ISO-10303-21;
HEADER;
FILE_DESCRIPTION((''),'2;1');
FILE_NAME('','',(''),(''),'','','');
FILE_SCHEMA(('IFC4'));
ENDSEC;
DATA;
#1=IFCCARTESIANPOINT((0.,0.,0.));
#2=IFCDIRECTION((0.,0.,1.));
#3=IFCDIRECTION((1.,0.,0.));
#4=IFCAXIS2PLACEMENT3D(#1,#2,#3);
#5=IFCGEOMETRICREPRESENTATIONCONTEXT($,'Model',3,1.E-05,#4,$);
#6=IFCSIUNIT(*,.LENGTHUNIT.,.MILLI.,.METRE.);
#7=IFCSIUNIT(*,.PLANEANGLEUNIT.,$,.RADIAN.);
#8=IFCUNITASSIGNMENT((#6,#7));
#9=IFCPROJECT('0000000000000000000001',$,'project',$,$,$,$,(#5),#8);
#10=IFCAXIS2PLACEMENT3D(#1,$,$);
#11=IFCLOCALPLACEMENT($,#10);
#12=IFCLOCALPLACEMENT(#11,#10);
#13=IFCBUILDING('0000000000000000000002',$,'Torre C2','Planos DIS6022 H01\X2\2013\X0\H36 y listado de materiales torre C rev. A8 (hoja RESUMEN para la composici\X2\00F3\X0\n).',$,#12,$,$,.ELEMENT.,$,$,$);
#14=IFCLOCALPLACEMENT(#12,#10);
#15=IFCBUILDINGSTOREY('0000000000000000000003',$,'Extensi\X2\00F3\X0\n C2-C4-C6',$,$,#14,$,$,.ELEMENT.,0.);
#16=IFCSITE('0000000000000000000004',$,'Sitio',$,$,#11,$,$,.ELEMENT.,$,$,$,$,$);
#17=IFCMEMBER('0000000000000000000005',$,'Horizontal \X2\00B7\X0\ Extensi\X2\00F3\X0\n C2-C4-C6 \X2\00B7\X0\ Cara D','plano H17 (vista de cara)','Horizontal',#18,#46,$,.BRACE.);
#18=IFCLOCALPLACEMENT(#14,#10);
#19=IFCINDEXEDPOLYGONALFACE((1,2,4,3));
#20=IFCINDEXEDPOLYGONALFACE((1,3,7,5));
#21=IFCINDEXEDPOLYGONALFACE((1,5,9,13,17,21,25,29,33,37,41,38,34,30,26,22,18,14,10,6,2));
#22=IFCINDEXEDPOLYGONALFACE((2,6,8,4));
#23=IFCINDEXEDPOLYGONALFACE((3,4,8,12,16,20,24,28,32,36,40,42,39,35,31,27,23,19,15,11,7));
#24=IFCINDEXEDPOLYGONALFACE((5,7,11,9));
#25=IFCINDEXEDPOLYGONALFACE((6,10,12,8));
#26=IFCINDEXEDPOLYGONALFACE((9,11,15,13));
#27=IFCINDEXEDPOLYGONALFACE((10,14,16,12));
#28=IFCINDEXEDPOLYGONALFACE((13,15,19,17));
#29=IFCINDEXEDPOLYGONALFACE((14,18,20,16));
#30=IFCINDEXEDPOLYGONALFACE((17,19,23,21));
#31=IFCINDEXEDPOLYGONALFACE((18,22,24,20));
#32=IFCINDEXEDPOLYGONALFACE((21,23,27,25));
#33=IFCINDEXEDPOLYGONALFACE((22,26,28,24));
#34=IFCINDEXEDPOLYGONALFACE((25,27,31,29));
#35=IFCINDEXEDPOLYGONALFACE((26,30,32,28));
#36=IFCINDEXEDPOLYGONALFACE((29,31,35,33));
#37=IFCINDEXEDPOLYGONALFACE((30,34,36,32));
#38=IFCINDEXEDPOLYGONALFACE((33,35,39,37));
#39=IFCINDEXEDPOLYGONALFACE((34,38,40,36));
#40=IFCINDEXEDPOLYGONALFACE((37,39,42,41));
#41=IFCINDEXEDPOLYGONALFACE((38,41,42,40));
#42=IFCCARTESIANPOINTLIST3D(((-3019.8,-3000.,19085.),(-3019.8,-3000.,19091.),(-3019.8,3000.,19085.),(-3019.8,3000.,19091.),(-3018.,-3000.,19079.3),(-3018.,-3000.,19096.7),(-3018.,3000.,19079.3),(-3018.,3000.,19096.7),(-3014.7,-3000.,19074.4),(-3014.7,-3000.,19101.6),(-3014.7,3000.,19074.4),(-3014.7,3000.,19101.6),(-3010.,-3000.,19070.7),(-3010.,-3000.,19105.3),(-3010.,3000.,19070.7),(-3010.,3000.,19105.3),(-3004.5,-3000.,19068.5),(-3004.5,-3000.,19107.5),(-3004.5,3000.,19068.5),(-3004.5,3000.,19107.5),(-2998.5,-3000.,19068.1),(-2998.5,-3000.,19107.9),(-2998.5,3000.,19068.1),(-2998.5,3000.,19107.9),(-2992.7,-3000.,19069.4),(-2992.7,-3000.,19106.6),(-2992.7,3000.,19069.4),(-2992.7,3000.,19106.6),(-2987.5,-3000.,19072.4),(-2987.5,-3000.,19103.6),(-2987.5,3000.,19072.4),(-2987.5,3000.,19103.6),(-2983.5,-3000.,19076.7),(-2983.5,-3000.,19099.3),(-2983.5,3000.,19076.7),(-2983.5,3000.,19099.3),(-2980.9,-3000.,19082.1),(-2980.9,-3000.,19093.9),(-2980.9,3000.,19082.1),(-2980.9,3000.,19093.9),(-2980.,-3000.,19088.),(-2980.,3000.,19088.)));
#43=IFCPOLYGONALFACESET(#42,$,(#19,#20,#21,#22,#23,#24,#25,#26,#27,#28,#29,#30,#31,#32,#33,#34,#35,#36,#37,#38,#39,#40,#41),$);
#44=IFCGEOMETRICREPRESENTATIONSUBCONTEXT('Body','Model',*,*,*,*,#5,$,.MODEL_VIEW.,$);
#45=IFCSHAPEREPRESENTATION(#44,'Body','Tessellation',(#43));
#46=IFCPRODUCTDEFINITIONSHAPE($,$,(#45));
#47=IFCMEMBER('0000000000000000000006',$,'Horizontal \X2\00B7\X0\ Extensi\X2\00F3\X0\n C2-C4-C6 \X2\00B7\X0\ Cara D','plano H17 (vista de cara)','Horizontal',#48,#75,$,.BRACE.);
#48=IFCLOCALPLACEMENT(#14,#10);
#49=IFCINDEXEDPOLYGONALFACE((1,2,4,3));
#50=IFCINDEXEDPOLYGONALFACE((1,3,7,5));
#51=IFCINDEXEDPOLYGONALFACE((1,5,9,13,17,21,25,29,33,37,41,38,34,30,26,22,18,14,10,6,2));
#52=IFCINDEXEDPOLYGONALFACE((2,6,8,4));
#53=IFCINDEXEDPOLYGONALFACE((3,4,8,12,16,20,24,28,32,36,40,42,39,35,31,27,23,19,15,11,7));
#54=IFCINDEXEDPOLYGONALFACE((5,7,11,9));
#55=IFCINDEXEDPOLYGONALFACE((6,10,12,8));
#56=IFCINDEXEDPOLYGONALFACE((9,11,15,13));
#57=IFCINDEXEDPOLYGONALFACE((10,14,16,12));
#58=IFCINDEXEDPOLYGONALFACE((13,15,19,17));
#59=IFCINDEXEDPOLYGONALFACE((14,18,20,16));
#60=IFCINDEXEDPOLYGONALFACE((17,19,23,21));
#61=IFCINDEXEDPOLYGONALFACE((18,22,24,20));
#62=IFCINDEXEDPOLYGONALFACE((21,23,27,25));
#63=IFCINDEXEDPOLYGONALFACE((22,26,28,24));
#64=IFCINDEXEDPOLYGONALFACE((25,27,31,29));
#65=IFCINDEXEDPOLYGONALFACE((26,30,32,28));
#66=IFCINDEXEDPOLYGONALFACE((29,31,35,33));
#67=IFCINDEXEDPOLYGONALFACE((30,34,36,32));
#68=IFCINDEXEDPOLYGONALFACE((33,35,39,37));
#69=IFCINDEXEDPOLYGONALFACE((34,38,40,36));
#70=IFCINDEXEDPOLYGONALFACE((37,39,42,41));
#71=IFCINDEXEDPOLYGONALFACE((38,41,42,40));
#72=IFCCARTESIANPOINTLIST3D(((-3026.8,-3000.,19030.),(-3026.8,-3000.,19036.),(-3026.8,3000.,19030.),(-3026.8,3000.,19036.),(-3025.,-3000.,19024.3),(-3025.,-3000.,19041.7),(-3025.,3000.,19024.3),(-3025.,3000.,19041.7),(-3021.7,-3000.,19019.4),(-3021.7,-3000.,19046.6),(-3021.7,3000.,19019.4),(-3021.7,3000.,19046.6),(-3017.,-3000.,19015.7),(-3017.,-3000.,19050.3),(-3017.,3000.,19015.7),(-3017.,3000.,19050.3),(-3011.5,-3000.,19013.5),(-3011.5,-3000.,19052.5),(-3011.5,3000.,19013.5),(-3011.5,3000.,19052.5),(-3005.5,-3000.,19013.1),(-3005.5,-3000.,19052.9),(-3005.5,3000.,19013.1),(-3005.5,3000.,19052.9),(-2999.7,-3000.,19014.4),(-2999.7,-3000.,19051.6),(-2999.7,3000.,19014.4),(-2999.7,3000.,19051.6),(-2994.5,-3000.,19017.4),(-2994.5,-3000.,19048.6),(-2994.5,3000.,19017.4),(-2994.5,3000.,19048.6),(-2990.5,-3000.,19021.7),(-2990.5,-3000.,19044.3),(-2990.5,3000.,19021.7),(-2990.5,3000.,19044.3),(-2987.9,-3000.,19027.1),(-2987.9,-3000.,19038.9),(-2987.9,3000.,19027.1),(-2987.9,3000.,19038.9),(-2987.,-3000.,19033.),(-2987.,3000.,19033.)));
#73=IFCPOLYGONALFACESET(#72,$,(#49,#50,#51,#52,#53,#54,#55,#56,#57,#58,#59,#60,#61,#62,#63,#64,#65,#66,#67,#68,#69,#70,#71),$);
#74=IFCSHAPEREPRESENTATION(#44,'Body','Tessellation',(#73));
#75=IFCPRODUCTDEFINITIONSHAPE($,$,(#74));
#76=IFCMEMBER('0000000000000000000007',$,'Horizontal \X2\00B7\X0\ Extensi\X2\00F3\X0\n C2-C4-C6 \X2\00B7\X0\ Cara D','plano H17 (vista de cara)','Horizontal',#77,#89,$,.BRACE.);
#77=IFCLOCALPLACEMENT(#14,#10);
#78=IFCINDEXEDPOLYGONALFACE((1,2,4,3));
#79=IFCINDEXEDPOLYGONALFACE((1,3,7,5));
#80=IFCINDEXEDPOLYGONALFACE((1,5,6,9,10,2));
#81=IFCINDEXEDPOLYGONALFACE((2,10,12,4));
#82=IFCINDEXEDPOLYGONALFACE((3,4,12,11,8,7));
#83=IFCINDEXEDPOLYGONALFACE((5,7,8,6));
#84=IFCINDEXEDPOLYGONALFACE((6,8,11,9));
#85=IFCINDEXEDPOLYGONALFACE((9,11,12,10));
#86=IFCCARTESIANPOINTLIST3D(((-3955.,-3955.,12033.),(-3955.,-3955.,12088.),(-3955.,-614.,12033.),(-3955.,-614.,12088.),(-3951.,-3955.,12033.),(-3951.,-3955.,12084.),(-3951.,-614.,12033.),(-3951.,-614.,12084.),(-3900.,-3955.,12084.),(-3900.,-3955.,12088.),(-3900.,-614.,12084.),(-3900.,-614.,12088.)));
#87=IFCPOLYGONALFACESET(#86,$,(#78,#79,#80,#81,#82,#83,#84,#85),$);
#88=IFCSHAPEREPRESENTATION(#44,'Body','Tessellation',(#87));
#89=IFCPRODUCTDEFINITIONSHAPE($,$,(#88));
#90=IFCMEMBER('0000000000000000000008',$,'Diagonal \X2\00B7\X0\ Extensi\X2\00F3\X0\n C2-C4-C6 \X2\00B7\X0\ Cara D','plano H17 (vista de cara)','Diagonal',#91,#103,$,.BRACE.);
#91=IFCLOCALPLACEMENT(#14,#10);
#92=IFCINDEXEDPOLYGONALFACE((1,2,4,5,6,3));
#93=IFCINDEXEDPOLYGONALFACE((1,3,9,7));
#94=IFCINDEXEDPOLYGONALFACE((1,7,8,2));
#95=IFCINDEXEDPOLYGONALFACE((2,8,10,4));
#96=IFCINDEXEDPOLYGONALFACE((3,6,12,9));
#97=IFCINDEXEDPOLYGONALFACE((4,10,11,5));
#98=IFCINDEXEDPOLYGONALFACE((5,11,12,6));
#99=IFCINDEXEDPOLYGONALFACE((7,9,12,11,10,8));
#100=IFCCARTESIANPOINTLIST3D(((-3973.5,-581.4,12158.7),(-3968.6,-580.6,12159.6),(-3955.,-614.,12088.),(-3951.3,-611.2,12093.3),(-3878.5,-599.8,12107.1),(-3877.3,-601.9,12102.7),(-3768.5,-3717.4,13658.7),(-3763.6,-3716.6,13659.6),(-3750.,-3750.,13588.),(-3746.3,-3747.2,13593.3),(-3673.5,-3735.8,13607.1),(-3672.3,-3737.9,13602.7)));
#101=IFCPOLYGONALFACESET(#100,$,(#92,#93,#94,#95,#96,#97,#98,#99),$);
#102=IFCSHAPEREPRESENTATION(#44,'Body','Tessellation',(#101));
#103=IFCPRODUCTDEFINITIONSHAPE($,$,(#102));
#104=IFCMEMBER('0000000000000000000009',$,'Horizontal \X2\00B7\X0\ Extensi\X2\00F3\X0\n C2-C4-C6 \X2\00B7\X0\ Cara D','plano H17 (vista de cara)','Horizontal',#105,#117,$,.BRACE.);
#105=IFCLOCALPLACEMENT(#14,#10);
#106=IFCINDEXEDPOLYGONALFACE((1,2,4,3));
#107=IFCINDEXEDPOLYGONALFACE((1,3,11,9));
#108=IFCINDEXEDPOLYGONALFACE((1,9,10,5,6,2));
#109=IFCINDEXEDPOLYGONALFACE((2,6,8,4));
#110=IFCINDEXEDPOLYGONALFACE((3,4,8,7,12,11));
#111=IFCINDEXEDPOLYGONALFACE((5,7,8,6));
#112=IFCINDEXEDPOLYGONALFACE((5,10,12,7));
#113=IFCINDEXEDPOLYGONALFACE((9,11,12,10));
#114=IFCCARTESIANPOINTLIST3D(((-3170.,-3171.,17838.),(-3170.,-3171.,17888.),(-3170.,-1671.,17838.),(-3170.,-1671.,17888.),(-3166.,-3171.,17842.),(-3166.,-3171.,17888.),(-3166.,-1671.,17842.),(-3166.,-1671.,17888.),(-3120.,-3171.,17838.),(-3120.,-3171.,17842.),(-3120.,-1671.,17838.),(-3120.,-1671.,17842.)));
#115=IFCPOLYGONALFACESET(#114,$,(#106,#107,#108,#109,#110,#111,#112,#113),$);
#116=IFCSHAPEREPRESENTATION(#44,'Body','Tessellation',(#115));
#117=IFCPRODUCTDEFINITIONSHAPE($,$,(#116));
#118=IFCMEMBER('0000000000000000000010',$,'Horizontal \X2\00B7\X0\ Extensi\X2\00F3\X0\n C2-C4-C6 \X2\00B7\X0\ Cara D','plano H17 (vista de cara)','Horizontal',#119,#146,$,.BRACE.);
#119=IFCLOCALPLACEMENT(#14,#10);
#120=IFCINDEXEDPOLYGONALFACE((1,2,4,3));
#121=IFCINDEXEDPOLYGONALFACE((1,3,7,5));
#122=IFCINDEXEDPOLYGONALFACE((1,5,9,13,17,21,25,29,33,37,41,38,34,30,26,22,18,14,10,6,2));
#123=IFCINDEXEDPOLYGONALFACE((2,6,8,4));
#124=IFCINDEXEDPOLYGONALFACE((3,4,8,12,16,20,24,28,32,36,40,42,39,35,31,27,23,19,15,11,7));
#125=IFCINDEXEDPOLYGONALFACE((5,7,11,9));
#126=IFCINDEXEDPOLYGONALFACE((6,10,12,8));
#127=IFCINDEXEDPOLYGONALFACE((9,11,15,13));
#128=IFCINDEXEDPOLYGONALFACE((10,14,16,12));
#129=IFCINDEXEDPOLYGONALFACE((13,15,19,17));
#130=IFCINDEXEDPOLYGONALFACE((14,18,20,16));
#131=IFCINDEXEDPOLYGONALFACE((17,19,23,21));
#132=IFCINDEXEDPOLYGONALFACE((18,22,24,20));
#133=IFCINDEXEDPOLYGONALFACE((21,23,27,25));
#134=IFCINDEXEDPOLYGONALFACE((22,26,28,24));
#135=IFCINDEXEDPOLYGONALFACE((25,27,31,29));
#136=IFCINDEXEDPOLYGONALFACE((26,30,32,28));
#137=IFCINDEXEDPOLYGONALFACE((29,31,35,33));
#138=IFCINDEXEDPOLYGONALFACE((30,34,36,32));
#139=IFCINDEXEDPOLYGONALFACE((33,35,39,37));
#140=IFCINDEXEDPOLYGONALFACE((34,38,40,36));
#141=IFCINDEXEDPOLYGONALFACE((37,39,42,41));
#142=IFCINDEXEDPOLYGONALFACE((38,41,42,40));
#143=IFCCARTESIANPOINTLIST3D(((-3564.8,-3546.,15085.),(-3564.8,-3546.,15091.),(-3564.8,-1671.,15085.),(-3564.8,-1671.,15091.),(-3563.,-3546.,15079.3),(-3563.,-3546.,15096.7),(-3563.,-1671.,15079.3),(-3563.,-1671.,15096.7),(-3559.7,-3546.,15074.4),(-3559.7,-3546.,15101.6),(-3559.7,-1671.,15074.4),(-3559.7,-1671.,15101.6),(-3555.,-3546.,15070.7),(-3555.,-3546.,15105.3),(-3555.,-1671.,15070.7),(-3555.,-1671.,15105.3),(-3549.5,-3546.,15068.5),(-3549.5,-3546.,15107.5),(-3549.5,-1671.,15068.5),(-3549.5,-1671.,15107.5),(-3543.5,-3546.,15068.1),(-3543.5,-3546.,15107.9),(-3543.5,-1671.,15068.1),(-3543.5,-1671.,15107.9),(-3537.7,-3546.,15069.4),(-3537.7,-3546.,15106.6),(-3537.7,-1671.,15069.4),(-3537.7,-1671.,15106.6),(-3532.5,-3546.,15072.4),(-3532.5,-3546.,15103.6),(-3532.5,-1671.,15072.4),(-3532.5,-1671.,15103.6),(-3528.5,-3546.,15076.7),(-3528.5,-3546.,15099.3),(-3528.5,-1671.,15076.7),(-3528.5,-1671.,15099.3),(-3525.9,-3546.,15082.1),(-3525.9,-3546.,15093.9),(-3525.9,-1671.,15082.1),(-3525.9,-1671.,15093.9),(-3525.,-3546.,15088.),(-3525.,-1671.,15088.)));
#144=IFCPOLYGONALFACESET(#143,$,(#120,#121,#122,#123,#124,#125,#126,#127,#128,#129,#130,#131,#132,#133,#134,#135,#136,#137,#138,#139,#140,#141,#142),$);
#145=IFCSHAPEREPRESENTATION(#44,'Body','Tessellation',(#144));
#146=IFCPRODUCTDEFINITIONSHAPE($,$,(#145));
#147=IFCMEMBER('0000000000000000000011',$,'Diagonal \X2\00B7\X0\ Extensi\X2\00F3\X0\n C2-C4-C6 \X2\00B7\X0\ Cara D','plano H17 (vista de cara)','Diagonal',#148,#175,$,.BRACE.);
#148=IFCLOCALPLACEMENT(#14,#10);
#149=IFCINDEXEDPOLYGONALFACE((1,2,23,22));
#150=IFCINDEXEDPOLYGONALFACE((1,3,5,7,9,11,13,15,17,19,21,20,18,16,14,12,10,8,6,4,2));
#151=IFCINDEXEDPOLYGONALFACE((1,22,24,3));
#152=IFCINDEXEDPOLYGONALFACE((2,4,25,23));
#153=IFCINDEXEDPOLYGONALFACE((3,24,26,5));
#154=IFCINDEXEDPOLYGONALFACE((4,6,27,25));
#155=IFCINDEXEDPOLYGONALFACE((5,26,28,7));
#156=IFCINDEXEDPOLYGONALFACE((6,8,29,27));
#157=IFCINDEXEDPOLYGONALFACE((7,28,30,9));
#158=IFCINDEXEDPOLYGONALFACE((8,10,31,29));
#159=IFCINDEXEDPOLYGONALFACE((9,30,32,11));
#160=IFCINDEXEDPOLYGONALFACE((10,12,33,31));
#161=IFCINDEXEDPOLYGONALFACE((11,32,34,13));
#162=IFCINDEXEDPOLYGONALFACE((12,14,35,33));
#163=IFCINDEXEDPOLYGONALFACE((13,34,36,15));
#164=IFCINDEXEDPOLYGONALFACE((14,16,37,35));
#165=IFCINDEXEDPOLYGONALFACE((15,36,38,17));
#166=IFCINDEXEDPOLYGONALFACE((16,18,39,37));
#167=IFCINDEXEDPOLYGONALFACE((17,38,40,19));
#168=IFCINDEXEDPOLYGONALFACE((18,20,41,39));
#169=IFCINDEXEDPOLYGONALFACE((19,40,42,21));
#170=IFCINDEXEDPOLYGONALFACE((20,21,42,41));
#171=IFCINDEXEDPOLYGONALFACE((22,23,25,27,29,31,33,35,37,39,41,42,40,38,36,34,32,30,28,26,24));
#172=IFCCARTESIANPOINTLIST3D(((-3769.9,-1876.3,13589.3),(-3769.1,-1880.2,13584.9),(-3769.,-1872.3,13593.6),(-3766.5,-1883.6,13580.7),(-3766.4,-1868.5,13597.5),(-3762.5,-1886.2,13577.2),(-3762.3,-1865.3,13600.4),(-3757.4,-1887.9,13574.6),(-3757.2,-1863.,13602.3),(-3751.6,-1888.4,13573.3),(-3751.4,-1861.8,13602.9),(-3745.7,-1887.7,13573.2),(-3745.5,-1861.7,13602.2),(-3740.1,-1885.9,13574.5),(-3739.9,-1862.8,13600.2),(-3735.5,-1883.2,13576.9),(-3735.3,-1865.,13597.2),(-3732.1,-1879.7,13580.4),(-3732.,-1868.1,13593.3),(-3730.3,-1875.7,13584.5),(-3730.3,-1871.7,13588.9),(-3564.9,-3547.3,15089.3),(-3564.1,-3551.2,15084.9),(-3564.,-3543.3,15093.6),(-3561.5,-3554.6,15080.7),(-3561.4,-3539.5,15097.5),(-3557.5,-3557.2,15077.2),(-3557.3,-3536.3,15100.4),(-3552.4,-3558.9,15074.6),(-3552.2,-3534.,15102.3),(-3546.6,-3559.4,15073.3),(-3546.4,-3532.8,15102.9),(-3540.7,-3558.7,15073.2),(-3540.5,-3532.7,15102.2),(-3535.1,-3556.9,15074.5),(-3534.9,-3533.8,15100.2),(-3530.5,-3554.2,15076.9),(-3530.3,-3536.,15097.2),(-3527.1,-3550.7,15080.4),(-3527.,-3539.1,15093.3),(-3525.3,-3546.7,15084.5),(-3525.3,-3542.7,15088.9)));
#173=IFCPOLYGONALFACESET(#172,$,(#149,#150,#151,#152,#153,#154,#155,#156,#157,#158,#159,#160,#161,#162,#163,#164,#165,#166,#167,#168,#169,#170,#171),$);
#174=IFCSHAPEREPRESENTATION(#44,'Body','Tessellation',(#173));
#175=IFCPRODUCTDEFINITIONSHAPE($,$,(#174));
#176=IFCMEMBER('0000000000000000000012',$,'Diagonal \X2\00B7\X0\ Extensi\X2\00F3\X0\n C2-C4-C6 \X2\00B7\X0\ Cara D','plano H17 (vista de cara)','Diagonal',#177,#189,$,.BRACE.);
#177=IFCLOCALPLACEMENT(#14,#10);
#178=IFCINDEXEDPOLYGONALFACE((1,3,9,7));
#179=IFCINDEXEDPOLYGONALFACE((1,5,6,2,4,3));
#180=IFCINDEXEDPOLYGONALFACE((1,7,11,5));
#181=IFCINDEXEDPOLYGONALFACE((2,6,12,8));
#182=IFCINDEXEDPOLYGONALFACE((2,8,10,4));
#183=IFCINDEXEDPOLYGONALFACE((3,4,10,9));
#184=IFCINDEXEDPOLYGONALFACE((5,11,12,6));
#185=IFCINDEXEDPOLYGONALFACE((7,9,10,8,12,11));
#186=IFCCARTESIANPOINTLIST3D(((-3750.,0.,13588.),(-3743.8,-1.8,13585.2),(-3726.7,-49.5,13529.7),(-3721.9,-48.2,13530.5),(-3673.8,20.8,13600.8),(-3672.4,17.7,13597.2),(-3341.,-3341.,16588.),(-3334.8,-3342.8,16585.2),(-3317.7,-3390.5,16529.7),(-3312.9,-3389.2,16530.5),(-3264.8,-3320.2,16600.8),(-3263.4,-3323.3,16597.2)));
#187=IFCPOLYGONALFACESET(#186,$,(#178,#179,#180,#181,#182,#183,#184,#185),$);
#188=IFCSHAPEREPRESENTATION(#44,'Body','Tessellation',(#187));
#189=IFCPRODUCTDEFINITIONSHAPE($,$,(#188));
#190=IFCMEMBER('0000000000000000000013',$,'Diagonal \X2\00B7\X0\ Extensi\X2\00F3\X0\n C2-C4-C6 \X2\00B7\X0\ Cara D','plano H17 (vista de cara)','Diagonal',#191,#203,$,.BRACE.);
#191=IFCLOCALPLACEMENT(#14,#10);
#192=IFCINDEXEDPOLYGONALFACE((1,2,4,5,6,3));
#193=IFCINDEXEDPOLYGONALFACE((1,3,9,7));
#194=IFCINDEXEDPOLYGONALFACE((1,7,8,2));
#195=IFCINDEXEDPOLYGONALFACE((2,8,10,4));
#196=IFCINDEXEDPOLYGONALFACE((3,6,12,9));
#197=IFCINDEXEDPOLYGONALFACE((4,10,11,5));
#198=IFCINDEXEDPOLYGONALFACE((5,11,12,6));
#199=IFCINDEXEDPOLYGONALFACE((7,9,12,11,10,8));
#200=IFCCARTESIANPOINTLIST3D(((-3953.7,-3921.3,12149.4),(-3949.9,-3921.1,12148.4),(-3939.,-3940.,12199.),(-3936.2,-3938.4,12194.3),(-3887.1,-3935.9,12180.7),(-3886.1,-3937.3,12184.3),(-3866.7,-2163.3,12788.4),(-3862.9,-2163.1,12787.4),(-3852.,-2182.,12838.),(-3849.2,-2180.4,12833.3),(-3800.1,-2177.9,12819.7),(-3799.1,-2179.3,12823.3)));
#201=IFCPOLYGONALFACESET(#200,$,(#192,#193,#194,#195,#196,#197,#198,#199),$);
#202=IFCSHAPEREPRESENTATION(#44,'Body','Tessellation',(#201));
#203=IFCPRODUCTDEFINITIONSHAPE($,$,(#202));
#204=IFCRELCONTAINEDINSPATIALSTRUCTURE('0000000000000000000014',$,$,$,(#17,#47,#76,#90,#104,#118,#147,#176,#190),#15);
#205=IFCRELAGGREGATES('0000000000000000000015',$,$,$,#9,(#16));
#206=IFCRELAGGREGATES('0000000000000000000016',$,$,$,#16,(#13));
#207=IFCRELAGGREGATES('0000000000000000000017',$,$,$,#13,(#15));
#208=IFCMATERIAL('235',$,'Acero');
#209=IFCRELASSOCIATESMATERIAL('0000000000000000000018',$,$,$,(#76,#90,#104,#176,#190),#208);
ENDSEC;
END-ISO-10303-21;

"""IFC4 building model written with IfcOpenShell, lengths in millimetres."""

from ifc_helpers import new_model, si_unit, frame, frame_2d, origin, origin_with_axes, place, context, subcontext, project, spatial, circle, l_section, extrude, material, element, save


model = new_model("IFC4")

# Units and contexts
model_context = context("Model", 3, precision=1e-05, world=origin_with_axes())
body_context = subcontext(model_context, "Body", "Model", "MODEL_VIEW")
ifc_project = project(units=[si_unit("LENGTHUNIT", "METRE", prefix="MILLI"), si_unit("PLANEANGLEUNIT", "RADIAN")], contexts=[model_context])

# Site, building, storey
site_placement = place(None, origin())
site = spatial("IfcSite", under=ifc_project, at=site_placement, Name="Sitio", CompositionType="ELEMENT")
building_placement = place(site_placement, origin())
building = spatial("IfcBuilding", under=site, at=building_placement, Name="Torre C2", Description="Planos DIS6022 H01–H36 y listado de materiales torre C rev. A8 (hoja RESUMEN para la composición).", CompositionType="ELEMENT")
storey_placement = place(building_placement, origin())
storey = spatial("IfcBuildingStorey", under=building, at=storey_placement, Name="Extensión C2-C4-C6", CompositionType="ELEMENT", Elevation=0.0)

# Members
ifc_material_1 = material(Name="235", Category="Acero")
for number, where, z_axis, x_axis, name in (
    (1, (-3000.0, -3000.0, 19088.0), (0.0, 1.0, 0.0), (1.0, 0.0, 0.0), "Horizontal · Extensión C2-C4-C6 · Cara D"),
    (2, (-3007.0, -3000.0, 19033.0), (0.0, 1.0, 0.0), (1.0, 0.0, 0.0), "Horizontal · Extensión C2-C4-C6 · Cara D"),
):
    element("IfcMember", number, at=place(storey_placement, frame(where, z_axis=z_axis, x_axis=x_axis)), inside=storey, Name=name, Description="plano H17 (vista de cara)", ObjectType="Horizontal", PredefinedType="BRACE", context=body_context, shape_type="SweptSolid", body=[
        extrude(circle(Radius=20.0), None, (0.0, 0.0, 1.0), 6000.0),
    ])
member_1_placement = place(storey_placement, frame((-3955.0, -3955.0, 12088.0), z_axis=(0.0, 1.0, 0.0), x_axis=(1.0, 0.0, 0.0)))
element("IfcMember", 3, at=member_1_placement, inside=storey, material=ifc_material_1, Name="Horizontal · Extensión C2-C4-C6 · Cara D", Description="plano H17 (vista de cara)", ObjectType="Horizontal", PredefinedType="BRACE", context=body_context, shape_type="SweptSolid", body=[
    extrude(l_section(Depth=55.0, Width=55.0, Thickness=4.0, at=frame_2d((27.5, 27.5))), None, (0.0, 0.0, 1.0), 3341.0),
])
member_2_placement = place(storey_placement, frame((-3955.0, -614.0, 12088.0), z_axis=(0.058869, -0.90055, 0.430748), x_axis=(0.971215, 0.151437, 0.183871)))
element("IfcMember", 4, at=member_2_placement, inside=storey, material=ifc_material_1, Name="Diagonal · Extensión C2-C4-C6 · Cara D", Description="plano H17 (vista de cara)", ObjectType="Diagonal", PredefinedType="BRACE", context=body_context, shape_type="SweptSolid", body=[
    extrude(l_section(Depth=80.0, Width=80.0, Thickness=5.0, at=frame_2d((40.0, 40.0))), None, (0.0, 0.0, 1.0), 3482.3),
])
member_3_placement = place(storey_placement, frame((-3170.0, -1671.0, 17838.0), z_axis=(0.0, -1.0, 0.0), x_axis=(1.0, 0.0, 0.0)))
element("IfcMember", 5, at=member_3_placement, inside=storey, material=ifc_material_1, Name="Horizontal · Extensión C2-C4-C6 · Cara D", Description="plano H17 (vista de cara)", ObjectType="Horizontal", PredefinedType="BRACE", context=body_context, shape_type="SweptSolid", body=[
    extrude(l_section(Depth=50.0, Width=50.0, Thickness=4.0, at=frame_2d((25.0, 25.0))), None, (0.0, 0.0, 1.0), 1500.0),
])
member_4_placement = place(storey_placement, frame((-3545.0, -1671.0, 15088.0), z_axis=(0.0, -1.0, 0.0), x_axis=(1.0, 0.0, 0.0)))
element("IfcMember", 6, at=member_4_placement, inside=storey, Name="Horizontal · Extensión C2-C4-C6 · Cara D", Description="plano H17 (vista de cara)", ObjectType="Horizontal", PredefinedType="BRACE", context=body_context, shape_type="SweptSolid", body=[
    extrude(circle(Radius=20.0), None, (0.0, 0.0, 1.0), 1875.0),
])
member_5_placement = place(storey_placement, frame((-3545.0, -3546.0, 15088.0), z_axis=(-0.090916, 0.741075, -0.665238), x_axis=(0.899707, 0.347494, 0.264149)))
element("IfcMember", 7, at=member_5_placement, inside=storey, Name="Diagonal · Extensión C2-C4-C6 · Cara D", Description="plano H17 (vista de cara)", ObjectType="Diagonal", PredefinedType="BRACE", context=body_context, shape_type="SweptSolid", body=[
    extrude(circle(Radius=20.0), None, (0.0, 0.0, 1.0), 2254.8),
])
member_6_placement = place(storey_placement, frame((-3341.0, -3341.0, 16588.0), z_axis=(-0.090711, 0.74099, -0.665361), x_axis=(0.952207, 0.260212, 0.159972)))
element("IfcMember", 8, at=member_6_placement, inside=storey, material=ifc_material_1, Name="Diagonal · Extensión C2-C4-C6 · Cara D", Description="plano H17 (vista de cara)", ObjectType="Diagonal", PredefinedType="BRACE", context=body_context, shape_type="SweptSolid", body=[
    extrude(l_section(Depth=80.0, Width=80.0, Thickness=5.0, at=frame_2d((40.0, 40.0))), None, (0.0, 0.0, 1.0), 4508.8),
])
member_7_placement = place(storey_placement, frame((-3939.0, -3940.0, 12199.0), z_axis=(0.046461, 0.938825, 0.341245), x_axis=(0.962352, 0.049518, -0.267257)))
element("IfcMember", 9, at=member_7_placement, inside=storey, material=ifc_material_1, Name="Diagonal · Extensión C2-C4-C6 · Cara D", Description="plano H17 (vista de cara)", ObjectType="Diagonal", PredefinedType="BRACE", context=body_context, shape_type="SweptSolid", body=[
    extrude(l_section(Depth=55.0, Width=55.0, Thickness=4.0, at=frame_2d((27.5, 27.5))), None, (0.0, 0.0, 1.0), 1872.6),
])

save(model, "model.ifc")
